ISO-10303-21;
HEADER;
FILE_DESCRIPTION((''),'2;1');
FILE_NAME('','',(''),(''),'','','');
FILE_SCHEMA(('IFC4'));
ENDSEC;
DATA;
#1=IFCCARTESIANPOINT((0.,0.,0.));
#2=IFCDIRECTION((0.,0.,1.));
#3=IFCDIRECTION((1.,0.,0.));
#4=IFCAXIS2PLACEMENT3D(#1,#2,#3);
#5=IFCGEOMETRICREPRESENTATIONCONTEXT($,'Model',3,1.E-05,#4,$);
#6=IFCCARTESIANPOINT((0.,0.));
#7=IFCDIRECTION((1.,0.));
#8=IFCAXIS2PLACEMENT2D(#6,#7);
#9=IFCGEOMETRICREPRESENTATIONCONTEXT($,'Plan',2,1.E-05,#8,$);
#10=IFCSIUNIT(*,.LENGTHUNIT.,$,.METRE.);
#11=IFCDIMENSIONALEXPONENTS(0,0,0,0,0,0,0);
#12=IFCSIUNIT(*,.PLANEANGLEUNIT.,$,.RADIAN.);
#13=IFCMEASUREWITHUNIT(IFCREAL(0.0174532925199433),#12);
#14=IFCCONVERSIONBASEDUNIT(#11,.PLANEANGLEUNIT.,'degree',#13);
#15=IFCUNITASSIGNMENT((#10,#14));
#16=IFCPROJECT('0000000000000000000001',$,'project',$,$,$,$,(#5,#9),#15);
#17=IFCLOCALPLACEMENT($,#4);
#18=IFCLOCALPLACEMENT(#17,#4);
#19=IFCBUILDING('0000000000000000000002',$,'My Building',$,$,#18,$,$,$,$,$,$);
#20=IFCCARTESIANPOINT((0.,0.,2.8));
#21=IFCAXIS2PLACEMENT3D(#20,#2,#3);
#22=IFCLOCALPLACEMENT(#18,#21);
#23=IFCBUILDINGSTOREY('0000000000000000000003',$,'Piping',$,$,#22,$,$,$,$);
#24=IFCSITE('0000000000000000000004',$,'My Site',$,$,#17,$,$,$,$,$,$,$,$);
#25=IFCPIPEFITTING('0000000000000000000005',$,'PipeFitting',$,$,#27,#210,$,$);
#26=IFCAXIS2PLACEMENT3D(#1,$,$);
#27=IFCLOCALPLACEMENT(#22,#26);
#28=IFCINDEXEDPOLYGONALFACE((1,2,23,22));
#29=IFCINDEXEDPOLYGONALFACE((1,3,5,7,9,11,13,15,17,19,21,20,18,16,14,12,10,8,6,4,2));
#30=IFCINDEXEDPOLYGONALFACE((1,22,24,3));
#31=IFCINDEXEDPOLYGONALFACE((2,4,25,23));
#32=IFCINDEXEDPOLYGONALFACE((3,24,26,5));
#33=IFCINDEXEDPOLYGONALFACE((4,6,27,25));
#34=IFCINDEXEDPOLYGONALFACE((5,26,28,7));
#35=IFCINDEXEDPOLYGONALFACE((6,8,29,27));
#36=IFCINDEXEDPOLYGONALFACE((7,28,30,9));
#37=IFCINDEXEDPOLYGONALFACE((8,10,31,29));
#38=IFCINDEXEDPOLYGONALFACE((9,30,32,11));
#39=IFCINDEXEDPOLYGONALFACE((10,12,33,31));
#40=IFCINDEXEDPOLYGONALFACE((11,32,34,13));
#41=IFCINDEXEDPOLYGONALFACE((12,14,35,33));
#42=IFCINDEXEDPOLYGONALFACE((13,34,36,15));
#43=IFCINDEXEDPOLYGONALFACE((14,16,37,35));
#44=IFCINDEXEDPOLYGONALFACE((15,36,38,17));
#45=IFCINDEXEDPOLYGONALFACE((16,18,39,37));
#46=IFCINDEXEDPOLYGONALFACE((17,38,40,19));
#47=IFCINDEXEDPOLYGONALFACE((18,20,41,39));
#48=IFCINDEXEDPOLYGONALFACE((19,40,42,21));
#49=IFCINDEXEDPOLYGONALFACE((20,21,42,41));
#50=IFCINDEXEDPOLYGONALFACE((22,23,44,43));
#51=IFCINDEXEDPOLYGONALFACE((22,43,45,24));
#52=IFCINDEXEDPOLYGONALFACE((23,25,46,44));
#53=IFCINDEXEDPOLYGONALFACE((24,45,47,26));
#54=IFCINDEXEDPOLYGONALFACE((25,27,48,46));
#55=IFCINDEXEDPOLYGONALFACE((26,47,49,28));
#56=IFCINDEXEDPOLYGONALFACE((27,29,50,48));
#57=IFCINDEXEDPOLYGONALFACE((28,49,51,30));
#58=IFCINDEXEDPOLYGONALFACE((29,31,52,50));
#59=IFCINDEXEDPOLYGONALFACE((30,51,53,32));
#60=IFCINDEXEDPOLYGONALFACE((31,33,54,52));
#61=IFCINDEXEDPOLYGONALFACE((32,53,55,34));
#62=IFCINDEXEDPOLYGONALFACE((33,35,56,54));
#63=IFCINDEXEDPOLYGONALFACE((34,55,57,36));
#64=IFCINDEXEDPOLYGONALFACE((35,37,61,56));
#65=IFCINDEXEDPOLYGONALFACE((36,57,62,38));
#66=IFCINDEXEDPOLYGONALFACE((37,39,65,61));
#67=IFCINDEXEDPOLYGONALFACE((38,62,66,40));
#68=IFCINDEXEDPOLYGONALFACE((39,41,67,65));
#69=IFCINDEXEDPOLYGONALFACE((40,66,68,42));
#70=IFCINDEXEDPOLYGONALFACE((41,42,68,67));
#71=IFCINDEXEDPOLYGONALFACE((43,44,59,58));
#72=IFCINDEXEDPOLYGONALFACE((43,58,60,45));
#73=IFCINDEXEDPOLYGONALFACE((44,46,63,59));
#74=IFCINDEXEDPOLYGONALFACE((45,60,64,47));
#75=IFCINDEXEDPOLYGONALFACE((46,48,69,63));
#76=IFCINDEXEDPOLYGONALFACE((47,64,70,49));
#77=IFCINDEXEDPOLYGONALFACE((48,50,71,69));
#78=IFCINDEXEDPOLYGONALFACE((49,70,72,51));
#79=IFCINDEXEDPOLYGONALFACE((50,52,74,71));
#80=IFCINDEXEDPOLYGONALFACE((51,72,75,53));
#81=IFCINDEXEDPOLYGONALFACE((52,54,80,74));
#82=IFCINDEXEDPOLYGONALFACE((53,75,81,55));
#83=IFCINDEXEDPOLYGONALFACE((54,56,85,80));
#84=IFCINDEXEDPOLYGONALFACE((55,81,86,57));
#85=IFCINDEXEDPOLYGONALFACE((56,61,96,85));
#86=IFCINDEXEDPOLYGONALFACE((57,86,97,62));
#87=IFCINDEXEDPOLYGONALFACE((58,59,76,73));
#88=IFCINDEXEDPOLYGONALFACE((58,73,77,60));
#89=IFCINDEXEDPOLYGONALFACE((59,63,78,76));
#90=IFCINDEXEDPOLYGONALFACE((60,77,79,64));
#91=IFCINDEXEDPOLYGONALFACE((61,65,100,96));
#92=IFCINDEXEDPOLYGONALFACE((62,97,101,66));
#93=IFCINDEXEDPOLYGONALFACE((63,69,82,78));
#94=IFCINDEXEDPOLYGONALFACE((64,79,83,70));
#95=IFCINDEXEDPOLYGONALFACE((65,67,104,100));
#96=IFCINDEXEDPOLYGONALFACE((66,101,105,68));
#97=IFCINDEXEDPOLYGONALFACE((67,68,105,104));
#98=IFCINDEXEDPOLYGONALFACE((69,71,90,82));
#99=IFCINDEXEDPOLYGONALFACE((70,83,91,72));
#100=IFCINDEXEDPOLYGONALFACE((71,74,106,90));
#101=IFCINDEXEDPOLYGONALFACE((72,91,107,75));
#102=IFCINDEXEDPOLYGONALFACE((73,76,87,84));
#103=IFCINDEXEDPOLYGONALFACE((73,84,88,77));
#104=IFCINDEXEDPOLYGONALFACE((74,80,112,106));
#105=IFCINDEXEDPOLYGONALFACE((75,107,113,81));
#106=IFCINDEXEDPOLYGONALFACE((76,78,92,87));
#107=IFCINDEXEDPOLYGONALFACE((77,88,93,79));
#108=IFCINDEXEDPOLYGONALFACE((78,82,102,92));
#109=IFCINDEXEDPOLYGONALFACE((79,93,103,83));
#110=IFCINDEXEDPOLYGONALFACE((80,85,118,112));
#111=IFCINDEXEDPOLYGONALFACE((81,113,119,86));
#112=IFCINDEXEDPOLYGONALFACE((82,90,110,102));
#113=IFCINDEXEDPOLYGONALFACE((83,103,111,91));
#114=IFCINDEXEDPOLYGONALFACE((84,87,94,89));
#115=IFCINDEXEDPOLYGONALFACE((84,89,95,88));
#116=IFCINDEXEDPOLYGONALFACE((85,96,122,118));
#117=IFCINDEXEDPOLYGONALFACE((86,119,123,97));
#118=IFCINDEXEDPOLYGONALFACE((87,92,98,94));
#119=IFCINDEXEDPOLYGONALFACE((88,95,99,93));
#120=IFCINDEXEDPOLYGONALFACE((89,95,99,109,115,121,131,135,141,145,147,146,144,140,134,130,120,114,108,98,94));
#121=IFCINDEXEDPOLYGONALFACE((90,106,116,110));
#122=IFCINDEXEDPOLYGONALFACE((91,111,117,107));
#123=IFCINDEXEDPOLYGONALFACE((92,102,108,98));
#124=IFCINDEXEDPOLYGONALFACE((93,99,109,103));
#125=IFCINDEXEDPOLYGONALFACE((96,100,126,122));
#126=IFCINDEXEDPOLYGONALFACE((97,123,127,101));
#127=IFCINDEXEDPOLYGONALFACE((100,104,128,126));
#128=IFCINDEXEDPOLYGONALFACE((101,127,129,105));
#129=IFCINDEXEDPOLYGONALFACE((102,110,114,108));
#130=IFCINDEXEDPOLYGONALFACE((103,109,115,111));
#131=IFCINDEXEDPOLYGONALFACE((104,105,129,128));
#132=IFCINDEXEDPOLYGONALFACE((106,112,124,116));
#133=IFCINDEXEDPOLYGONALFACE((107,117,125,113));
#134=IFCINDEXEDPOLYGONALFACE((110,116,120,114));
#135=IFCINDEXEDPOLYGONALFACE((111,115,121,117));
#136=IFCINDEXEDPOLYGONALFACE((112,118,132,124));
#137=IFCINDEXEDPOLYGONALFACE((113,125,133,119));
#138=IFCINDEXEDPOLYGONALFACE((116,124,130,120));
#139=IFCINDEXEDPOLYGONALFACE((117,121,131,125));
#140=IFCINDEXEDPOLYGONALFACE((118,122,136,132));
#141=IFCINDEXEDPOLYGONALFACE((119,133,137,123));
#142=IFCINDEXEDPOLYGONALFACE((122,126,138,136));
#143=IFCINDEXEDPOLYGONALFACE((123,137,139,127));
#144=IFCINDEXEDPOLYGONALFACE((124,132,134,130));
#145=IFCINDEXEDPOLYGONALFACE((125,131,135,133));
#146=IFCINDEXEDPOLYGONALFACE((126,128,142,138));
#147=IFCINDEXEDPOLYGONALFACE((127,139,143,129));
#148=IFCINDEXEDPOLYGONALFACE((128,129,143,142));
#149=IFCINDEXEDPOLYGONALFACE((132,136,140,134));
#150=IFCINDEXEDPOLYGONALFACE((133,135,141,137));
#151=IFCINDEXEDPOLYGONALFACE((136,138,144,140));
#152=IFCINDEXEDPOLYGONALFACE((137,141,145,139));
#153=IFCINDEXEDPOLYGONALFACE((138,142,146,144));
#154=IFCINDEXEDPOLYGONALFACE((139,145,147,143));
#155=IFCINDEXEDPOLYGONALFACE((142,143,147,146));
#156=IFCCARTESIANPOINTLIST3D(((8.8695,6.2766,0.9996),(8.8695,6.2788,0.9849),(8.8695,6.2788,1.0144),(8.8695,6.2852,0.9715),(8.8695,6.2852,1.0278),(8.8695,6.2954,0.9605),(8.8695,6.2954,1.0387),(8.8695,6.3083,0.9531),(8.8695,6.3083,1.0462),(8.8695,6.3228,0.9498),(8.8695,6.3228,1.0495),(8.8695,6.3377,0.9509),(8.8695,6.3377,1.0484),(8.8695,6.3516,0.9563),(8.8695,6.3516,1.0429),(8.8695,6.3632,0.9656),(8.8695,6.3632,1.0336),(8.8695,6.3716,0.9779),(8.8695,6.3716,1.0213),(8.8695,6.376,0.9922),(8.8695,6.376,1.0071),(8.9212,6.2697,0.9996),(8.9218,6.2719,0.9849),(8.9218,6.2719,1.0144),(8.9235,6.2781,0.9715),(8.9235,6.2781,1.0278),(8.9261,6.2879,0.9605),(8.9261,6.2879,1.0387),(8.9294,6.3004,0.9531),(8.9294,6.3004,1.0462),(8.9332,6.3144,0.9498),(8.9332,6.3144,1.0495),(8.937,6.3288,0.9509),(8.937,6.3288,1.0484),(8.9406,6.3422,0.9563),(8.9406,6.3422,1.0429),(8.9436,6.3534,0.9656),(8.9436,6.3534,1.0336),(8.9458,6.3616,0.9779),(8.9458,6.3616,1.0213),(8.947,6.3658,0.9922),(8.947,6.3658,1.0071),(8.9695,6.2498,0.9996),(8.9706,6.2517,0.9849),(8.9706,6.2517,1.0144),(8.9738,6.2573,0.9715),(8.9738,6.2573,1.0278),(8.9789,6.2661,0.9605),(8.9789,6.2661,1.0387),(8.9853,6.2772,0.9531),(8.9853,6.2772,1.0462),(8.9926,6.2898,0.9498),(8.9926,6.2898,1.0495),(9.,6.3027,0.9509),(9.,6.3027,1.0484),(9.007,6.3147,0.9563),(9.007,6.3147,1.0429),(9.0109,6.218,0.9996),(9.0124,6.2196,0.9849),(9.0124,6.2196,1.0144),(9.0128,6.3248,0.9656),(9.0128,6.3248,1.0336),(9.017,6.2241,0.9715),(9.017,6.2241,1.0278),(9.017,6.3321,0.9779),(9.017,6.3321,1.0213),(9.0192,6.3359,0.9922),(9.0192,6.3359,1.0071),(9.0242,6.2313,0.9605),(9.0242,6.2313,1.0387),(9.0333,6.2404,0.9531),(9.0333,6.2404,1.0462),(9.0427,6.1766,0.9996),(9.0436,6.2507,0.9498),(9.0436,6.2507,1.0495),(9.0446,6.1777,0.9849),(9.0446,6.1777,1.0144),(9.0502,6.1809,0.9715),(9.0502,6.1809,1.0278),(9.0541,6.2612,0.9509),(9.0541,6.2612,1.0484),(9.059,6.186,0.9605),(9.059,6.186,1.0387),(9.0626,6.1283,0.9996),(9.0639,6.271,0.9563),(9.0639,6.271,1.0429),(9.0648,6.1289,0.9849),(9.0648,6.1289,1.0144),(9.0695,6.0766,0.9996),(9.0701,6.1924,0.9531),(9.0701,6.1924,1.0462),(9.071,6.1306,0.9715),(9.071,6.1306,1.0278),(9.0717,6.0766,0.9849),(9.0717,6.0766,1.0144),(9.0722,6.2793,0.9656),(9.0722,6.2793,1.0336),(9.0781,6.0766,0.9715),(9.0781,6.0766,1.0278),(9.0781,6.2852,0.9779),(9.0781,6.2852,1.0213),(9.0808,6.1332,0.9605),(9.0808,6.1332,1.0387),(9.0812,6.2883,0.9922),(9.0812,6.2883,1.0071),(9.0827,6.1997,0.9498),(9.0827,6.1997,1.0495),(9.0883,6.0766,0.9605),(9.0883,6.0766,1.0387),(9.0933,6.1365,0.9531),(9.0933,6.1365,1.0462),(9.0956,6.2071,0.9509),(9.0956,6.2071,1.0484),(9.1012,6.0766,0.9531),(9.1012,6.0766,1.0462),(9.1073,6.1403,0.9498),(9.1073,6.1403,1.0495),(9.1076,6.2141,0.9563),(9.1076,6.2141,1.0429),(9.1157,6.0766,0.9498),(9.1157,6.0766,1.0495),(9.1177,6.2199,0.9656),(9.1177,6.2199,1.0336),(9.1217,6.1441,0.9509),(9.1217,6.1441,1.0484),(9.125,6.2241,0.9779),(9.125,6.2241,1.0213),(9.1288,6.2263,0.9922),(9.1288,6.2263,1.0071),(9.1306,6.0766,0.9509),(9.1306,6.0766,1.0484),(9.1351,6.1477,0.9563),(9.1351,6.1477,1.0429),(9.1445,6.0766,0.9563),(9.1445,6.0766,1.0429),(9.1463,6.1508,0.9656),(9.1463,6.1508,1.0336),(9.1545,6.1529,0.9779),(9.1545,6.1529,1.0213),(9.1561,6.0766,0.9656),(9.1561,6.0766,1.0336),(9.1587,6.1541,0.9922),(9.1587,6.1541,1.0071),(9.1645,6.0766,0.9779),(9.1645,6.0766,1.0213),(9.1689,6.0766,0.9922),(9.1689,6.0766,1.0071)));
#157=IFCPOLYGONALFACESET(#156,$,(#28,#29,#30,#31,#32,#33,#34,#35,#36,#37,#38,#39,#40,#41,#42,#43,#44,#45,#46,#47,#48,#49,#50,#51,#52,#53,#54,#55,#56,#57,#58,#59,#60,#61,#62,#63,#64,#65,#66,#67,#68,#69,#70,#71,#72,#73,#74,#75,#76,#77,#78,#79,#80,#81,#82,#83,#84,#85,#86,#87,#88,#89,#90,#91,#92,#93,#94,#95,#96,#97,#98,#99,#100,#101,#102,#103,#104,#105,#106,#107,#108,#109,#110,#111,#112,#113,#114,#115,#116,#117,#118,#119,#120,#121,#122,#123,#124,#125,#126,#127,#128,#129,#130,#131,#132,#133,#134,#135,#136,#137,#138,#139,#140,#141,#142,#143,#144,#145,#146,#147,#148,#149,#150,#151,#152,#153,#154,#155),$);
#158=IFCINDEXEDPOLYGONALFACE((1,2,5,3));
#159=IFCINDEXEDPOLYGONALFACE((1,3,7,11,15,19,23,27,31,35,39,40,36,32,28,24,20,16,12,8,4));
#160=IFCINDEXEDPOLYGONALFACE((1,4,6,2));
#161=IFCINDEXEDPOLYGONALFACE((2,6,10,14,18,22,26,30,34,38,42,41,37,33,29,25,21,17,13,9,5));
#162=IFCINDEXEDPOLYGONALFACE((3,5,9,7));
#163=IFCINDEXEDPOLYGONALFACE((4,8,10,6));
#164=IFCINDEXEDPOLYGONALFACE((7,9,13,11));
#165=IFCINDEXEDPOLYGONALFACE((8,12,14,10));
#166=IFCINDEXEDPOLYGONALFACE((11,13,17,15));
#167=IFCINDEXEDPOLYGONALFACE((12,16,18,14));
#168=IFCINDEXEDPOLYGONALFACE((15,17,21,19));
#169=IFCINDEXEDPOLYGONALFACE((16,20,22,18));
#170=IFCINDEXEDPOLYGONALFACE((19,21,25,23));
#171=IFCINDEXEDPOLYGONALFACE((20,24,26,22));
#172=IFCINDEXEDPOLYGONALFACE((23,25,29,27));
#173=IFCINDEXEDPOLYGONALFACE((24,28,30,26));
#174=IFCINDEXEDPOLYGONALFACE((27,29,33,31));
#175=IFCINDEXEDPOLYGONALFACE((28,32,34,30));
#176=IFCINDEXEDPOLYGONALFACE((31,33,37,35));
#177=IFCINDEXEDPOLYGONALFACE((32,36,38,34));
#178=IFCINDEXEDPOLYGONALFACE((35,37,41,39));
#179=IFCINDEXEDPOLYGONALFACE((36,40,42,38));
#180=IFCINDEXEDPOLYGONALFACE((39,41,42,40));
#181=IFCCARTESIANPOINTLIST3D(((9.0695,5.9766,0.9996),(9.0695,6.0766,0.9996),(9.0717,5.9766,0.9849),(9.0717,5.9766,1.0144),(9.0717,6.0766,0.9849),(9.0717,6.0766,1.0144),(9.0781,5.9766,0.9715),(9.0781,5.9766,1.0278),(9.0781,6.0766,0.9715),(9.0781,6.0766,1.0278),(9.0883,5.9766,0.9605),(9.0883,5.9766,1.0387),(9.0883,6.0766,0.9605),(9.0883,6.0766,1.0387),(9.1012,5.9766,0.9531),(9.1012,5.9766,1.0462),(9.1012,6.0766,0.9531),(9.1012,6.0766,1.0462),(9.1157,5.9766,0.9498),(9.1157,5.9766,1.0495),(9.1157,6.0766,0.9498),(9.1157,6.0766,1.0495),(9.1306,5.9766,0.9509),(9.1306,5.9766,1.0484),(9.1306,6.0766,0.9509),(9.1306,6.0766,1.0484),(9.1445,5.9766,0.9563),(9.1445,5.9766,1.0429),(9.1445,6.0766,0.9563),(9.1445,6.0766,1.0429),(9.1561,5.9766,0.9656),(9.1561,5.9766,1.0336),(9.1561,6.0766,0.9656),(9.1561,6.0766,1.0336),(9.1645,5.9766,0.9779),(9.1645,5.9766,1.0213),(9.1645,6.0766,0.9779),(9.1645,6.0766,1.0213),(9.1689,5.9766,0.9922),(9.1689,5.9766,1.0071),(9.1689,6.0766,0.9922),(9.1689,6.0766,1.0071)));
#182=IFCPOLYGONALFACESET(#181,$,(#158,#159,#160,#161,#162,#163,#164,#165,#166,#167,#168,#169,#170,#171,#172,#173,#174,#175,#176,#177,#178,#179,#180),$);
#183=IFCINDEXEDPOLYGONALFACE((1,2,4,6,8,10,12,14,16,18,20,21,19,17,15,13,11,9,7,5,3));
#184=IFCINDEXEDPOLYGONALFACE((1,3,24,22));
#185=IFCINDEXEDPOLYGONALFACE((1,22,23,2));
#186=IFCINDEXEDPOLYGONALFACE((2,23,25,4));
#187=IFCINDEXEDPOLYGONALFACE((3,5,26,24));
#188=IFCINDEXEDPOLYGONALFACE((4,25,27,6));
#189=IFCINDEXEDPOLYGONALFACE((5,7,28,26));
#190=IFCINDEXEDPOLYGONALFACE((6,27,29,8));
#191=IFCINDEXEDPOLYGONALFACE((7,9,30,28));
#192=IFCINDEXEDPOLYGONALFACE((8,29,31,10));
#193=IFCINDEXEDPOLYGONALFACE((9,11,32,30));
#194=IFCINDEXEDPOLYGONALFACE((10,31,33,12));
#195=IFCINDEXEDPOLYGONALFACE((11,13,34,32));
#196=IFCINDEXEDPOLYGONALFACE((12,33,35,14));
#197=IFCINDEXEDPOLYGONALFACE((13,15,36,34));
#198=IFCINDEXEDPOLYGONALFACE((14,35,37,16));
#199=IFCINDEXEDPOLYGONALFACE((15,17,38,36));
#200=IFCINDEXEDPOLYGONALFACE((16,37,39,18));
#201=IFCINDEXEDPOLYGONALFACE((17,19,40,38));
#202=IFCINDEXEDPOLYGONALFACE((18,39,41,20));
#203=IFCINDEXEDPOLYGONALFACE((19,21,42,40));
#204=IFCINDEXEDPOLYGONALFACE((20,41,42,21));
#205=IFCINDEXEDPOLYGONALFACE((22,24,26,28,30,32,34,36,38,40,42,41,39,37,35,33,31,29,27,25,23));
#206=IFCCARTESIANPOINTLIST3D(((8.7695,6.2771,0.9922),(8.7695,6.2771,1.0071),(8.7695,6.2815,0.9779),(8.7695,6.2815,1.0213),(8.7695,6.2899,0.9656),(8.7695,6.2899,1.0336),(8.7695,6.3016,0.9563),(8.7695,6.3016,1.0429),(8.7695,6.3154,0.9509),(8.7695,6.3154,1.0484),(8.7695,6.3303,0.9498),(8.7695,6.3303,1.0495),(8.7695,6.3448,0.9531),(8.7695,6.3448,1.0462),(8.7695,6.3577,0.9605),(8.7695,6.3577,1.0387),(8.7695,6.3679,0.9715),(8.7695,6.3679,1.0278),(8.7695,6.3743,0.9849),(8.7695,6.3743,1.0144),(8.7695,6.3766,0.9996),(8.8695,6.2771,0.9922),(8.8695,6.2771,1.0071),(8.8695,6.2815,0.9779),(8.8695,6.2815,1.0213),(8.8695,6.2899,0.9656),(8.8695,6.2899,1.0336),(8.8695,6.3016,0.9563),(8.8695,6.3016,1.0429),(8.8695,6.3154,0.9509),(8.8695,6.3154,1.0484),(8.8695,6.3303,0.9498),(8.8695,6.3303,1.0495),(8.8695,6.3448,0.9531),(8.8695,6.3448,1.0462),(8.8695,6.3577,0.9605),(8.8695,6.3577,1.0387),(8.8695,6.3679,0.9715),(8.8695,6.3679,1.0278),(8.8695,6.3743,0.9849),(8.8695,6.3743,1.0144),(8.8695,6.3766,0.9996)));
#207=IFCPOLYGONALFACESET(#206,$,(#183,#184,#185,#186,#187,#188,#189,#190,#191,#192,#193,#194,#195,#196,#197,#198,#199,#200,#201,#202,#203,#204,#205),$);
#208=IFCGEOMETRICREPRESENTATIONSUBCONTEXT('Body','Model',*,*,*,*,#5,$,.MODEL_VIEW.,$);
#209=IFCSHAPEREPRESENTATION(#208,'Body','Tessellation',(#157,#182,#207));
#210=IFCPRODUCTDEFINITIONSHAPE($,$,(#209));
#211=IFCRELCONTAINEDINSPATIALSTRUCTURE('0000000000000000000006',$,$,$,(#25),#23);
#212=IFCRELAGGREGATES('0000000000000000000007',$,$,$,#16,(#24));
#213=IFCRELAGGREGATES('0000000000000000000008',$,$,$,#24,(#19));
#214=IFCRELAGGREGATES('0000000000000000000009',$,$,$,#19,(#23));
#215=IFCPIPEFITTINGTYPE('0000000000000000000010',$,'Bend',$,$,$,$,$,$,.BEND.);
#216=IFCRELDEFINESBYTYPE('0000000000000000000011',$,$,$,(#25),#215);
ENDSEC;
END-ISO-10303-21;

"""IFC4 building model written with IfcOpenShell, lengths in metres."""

from ifc_helpers import new_model, entity, si_unit, converted_unit, frame, origin_with_axes, origin_2d_with_axis, place, context, subcontext, project, spatial, circle, extrude, source, transform, mapped, type_object, type_shapes, element, save


model = new_model("IFC4")

# Units and contexts
model_context = context("Model", 3, precision=1e-05, world=origin_with_axes())
plan_context = context("Plan", 2, precision=1e-05, world=origin_2d_with_axis())
body_context = subcontext(model_context, "Body", "Model", "MODEL_VIEW")
ifc_project = project(units=[si_unit("LENGTHUNIT", "METRE"), converted_unit("PLANEANGLEUNIT", "degree", entity("IfcReal", 0.0174532925199433), si_unit("PLANEANGLEUNIT", "RADIAN"), dimensions=[0, 0, 0, 0, 0, 0, 0])], contexts=[model_context, plan_context])

# Site, building, storey
site_placement = place(None, origin_with_axes())
site = spatial("IfcSite", under=ifc_project, at=site_placement, Name="My Site")
building_placement = place(site_placement, origin_with_axes())
building = spatial("IfcBuilding", under=site, at=building_placement, Name="My Building")
storey_placement = place(building_placement, frame((0.0, 0.0, 2.8), z_axis=(0.0, 0.0, 1.0), x_axis=(1.0, 0.0, 0.0)))
storey = spatial("IfcBuildingStorey", under=building, at=storey_placement, Name="Piping")

# Pipe fitting
pipe_fitting_type_1 = type_object("IfcPipeFittingType", Name="Bend", PredefinedType="BEND")
shared_shape = source(origin_with_axes(), body_context, "Body", "SolidModel", [
    entity("IfcSweptDiskSolid", entity("IfcIndexedPolyCurve", entity("IfcCartesianPointList3D", [[0.0, 0.0, 0.1], [0.0732, 0.0, 0.2768], [0.25, 0.0, 0.35]]), [entity("IfcArcIndex", [1, 2, 3])]), 0.05),
    extrude(circle(Radius=0.05), origin_with_axes(), (0.0, 0.0, 1.0), 0.1),
    extrude(circle(Radius=0.05), frame((0.25, 0.0, 0.35), z_axis=(1.0, 0.0, 0.0), x_axis=(0.0, 0.0, 1.0)), (0.0, 0.0, 1.0), 0.1),
])
type_shapes(pipe_fitting_type_1, [shared_shape])
for number, where, z_axis, x_axis, name in (
    (1, (9.1195, 5.9766, 0.9996), (0.0, 1.0, 0.0), (-1.0, 0.0, 0.0), "PipeFitting"),
):
    element("IfcPipeFitting", number, at=place(storey_placement, frame(where, z_axis=z_axis, x_axis=x_axis)), inside=storey, type_object=pipe_fitting_type_1, Name=name, context=body_context, shape_type="MappedRepresentation", body=[
        mapped(shared_shape, transform((0.0, 0.0, 0.0), x_axis=(1.0, 0.0, 0.0), y_axis=(0.0, 1.0, 0.0), z_axis=(0.0, 0.0, 1.0), scale=1.0)),
    ])

save(model, "model.ifc")
